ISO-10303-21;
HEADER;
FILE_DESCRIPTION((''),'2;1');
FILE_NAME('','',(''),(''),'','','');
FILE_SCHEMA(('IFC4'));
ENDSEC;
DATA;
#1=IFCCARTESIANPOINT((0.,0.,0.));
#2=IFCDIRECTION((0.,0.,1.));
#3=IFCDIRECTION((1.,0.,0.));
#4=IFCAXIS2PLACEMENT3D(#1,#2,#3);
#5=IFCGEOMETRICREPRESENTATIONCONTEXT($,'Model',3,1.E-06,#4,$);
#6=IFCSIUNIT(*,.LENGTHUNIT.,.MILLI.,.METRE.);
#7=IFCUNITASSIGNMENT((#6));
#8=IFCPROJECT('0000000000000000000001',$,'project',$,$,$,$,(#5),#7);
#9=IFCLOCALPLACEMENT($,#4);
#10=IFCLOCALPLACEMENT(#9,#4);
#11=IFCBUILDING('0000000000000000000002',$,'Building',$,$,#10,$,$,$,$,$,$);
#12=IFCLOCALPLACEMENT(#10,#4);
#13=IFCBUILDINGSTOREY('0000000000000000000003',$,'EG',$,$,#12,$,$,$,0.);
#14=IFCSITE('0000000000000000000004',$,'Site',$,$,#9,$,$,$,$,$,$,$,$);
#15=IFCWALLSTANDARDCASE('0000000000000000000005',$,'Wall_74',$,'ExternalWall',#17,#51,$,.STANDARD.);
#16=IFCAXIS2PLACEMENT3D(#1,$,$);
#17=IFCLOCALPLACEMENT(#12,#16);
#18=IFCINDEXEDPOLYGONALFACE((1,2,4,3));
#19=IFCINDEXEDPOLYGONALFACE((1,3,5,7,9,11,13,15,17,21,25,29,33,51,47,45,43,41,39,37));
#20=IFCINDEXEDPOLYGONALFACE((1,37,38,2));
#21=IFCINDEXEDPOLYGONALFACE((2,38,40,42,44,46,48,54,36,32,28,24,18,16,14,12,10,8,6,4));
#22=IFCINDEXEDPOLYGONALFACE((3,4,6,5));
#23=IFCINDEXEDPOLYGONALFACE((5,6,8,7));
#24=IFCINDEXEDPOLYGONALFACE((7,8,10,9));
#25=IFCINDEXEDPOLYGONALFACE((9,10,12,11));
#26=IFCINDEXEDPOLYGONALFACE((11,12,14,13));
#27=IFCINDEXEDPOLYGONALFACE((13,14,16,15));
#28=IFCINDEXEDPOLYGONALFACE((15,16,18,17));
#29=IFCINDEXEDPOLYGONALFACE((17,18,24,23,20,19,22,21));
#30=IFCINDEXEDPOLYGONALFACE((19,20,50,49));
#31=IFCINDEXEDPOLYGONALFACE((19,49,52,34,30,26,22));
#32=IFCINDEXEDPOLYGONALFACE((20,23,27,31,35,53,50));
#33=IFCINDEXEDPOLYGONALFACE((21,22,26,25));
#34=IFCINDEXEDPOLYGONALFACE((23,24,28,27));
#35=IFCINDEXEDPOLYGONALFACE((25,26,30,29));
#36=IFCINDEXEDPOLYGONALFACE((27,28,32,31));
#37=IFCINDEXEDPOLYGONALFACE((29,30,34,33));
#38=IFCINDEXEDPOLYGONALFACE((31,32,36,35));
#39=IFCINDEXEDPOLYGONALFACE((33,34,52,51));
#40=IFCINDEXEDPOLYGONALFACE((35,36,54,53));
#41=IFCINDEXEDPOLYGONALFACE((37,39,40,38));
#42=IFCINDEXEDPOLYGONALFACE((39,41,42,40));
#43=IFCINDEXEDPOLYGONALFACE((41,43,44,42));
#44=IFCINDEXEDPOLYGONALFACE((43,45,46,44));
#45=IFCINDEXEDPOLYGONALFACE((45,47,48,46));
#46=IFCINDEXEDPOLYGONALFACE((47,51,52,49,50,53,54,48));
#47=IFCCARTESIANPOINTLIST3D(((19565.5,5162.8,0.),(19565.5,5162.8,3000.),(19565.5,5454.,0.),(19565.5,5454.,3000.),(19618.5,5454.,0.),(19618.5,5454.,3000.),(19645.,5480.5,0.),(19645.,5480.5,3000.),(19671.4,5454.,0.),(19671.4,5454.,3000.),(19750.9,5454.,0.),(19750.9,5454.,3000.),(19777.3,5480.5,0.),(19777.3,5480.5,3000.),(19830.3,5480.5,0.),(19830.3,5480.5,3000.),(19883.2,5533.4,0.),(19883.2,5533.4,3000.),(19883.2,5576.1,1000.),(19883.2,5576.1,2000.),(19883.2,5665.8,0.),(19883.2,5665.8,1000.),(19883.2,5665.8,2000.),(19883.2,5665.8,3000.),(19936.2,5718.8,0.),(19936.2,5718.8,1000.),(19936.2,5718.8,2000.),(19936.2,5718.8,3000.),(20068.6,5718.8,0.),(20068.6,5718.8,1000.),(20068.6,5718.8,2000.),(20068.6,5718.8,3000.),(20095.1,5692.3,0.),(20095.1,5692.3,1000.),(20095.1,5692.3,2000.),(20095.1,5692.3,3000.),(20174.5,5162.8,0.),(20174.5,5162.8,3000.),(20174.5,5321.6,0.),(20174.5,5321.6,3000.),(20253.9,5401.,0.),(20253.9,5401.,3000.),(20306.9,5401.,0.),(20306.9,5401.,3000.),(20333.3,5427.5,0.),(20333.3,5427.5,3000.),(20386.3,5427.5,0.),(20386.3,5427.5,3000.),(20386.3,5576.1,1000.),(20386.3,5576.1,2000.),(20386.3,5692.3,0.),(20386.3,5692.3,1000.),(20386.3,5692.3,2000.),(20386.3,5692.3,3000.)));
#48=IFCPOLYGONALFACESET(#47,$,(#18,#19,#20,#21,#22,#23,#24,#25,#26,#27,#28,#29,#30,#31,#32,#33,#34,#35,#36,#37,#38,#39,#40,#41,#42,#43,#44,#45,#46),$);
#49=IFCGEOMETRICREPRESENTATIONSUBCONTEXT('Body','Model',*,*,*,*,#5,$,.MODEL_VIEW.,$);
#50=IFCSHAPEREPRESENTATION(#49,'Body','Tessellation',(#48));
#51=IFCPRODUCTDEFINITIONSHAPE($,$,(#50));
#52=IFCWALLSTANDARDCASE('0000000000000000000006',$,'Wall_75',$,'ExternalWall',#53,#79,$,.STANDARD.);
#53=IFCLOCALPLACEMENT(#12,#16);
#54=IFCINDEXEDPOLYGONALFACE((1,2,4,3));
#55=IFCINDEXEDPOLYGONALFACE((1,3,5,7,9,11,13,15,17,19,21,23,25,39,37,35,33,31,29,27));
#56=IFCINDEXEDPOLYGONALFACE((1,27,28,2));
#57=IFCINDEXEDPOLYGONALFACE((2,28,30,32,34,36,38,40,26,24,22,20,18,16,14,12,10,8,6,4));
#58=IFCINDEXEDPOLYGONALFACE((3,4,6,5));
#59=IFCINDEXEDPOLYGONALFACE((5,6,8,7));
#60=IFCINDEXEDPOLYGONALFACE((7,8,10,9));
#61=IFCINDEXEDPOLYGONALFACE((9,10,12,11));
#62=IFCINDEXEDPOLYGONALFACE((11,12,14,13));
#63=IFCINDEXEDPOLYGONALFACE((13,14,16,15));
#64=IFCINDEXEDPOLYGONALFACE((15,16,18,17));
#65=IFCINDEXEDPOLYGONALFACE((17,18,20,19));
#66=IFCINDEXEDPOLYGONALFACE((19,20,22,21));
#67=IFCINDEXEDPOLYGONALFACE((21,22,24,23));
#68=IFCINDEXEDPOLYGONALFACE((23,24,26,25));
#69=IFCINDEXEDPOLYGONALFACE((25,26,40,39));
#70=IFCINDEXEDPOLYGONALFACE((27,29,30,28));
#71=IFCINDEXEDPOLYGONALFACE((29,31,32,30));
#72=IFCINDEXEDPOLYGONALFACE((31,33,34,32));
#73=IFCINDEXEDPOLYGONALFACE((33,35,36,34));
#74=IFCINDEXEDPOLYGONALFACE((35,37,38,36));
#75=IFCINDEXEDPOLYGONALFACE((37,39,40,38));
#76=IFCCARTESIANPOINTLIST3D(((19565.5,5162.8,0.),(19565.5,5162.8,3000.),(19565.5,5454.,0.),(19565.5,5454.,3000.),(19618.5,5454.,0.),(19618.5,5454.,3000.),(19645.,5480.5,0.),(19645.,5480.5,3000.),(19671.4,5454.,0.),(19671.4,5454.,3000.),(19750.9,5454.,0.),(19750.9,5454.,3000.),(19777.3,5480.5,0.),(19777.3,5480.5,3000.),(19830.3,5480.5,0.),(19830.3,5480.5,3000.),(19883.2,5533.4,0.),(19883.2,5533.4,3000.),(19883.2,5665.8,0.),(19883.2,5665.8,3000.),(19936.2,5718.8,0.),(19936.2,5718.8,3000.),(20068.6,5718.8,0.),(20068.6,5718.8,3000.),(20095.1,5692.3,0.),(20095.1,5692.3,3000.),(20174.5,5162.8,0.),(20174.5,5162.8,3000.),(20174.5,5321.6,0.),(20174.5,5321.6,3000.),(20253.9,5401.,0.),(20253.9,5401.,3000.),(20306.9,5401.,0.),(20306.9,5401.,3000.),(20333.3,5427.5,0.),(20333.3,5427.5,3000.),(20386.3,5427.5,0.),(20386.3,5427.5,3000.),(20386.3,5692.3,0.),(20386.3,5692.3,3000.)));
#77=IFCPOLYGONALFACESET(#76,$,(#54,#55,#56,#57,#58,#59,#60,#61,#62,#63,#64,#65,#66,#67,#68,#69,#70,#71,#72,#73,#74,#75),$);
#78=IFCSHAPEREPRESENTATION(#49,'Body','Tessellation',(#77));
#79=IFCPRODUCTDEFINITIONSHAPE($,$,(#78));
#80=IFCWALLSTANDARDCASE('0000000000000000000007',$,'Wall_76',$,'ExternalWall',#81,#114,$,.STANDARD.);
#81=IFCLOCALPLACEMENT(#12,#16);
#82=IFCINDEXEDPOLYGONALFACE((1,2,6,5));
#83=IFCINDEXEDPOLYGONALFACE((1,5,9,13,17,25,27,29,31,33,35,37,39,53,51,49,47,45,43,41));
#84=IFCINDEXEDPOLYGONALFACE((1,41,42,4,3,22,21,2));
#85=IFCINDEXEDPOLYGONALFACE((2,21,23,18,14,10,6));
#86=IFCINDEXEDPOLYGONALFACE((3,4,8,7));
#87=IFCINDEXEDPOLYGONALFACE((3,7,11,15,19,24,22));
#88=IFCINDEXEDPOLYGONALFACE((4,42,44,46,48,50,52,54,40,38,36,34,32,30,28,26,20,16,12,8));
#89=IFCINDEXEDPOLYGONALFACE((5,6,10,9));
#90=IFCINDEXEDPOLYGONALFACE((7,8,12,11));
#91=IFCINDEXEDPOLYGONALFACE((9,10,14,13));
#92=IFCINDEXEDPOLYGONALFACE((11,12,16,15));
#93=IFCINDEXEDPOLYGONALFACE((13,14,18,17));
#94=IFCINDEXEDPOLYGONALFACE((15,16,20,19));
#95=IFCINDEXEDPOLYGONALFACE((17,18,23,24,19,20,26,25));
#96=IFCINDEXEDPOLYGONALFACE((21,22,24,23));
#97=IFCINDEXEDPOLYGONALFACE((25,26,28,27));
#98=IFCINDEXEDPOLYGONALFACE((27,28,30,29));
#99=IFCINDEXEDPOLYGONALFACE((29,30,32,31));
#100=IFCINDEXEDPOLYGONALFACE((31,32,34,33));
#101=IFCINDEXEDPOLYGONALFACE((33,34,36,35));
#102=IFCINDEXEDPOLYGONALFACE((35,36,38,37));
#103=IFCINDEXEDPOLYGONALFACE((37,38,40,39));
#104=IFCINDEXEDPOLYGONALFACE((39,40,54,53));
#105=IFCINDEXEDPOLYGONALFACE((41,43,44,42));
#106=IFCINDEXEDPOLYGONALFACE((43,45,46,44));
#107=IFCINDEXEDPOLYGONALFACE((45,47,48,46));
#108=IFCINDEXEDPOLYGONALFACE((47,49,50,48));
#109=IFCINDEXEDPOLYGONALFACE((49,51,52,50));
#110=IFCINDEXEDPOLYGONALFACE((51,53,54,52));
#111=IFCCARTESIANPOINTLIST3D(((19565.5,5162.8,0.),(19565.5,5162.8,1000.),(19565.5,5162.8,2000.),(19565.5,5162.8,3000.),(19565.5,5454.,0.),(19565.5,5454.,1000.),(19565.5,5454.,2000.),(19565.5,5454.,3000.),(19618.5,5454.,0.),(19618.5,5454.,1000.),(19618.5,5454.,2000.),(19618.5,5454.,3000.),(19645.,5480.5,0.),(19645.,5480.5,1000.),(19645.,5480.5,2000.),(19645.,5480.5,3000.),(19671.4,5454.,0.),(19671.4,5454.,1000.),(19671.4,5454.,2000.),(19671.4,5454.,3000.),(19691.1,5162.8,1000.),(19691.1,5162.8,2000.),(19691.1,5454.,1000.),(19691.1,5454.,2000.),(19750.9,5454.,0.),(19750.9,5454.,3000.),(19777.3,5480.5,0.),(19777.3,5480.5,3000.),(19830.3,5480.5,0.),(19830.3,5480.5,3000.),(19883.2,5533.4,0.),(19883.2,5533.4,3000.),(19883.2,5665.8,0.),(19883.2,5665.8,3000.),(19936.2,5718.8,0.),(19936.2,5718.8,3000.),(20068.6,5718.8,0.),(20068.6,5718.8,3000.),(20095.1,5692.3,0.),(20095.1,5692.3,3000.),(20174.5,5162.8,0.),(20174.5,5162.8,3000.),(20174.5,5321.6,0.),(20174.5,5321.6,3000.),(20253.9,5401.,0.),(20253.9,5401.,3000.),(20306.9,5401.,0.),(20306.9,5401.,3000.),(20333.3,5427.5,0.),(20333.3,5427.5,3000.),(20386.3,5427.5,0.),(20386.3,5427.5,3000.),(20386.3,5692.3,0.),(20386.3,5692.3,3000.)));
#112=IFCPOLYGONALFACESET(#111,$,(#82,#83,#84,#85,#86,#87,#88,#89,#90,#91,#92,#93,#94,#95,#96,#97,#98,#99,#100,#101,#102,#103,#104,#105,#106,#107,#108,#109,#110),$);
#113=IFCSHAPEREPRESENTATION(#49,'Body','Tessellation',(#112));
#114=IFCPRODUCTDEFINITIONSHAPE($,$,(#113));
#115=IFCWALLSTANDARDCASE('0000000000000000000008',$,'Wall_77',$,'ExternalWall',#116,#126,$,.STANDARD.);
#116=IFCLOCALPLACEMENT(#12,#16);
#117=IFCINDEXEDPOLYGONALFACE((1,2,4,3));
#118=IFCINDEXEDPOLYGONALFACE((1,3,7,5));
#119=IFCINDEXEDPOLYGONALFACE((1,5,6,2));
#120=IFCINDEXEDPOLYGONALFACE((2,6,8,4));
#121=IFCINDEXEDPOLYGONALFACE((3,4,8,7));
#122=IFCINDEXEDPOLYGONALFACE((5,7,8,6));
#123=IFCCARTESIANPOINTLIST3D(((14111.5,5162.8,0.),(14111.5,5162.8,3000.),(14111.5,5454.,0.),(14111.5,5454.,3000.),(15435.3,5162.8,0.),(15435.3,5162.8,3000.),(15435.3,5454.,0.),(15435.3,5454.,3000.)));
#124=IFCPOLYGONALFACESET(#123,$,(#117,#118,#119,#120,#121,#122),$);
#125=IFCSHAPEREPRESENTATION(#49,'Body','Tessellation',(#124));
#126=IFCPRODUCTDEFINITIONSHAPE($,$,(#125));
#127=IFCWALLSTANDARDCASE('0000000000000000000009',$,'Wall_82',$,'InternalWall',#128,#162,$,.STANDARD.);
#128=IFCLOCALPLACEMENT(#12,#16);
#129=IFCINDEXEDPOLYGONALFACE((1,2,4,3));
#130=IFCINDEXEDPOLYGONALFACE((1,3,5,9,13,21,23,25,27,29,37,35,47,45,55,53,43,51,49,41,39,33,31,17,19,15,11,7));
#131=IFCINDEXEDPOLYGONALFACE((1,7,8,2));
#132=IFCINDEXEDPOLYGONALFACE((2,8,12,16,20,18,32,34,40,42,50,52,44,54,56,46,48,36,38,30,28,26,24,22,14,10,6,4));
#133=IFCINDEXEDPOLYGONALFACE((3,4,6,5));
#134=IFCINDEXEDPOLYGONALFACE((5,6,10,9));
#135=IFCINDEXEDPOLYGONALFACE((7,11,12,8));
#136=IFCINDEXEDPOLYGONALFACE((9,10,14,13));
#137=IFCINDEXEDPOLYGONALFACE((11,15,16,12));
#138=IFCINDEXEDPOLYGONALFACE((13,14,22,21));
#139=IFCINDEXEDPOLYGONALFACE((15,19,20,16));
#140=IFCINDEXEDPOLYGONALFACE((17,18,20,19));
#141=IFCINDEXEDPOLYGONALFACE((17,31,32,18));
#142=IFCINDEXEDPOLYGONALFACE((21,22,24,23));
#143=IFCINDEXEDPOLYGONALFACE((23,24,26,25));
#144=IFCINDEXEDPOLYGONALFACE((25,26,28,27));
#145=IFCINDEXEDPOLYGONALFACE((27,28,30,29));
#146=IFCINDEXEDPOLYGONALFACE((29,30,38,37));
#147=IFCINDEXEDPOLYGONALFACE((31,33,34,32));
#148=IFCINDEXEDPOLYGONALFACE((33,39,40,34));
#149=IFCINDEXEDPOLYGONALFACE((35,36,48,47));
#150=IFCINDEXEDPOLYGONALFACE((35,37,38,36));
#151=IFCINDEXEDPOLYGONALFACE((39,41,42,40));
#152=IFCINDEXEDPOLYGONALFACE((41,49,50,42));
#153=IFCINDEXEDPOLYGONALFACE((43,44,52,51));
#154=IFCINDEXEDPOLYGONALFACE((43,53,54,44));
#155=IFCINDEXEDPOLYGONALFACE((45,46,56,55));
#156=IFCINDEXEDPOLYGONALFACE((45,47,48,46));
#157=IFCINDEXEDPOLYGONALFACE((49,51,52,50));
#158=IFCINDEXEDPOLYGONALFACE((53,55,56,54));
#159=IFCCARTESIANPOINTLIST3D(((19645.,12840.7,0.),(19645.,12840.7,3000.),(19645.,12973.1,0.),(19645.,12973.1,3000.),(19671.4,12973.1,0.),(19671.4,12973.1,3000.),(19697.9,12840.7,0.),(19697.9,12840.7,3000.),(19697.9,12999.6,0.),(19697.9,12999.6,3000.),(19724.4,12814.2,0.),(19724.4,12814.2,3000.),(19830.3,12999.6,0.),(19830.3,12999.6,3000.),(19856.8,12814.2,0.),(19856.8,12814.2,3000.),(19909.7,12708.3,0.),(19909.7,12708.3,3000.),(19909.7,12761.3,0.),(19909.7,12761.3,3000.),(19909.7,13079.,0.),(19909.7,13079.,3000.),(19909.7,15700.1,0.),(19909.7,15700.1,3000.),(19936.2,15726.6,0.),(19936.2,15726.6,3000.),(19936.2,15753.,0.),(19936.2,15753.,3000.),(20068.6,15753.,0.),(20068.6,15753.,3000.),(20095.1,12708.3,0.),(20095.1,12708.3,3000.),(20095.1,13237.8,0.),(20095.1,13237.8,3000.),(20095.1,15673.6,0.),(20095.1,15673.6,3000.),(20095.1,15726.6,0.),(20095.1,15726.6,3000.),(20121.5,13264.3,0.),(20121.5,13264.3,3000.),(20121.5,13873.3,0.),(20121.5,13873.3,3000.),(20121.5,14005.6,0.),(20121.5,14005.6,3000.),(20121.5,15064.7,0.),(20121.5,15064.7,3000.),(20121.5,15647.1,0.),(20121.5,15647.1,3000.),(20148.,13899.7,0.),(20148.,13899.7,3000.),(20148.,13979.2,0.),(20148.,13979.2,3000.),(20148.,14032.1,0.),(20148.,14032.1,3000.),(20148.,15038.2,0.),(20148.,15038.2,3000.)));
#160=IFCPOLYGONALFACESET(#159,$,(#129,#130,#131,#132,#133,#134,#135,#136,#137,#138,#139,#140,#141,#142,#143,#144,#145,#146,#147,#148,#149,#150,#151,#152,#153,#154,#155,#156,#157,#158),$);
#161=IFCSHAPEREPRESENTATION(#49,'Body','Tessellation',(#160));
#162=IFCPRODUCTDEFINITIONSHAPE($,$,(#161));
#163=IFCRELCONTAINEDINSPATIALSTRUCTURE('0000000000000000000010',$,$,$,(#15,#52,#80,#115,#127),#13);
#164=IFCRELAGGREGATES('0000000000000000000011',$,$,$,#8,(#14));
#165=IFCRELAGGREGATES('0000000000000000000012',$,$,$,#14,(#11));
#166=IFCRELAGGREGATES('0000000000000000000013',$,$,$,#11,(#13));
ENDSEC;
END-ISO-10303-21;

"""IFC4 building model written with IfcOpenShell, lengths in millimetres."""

from ifc_helpers import new_model, si_unit, frame, origin_with_axes, place, context, subcontext, project, spatial, polyline, rectangle, outline, extrude, element, save


model = new_model("IFC4")

# Units and contexts
model_context = context("Model", 3, precision=1e-06, world=origin_with_axes())
body_context = subcontext(model_context, "Body", "Model", "MODEL_VIEW")
ifc_project = project(units=[si_unit("LENGTHUNIT", "METRE", prefix="MILLI")], contexts=[model_context])

# Site, building, storey
site_placement = place(None, origin_with_axes())
site = spatial("IfcSite", under=ifc_project, at=site_placement, Name="Site")
building_placement = place(site_placement, origin_with_axes())
building = spatial("IfcBuilding", under=site, at=building_placement, Name="Building")
storey_placement = place(building_placement, origin_with_axes())
storey = spatial("IfcBuildingStorey", under=building, at=storey_placement, Name="EG", Elevation=0.0)

# Wall, opening
wall_1_placement = place(storey_placement, origin_with_axes())
wall_1 = element("IfcWallStandardCase", 1, at=wall_1_placement, inside=storey, Name="Wall_74", ObjectType="ExternalWall", PredefinedType="STANDARD", context=body_context, shape_type="SweptSolid", body=[
    extrude(outline(polyline([(19565.5, 5162.8, 0.0), (19565.5, 5454.0, 0.0), (19618.5, 5454.0, 0.0), (19645.0, 5480.5, 0.0), (19671.4, 5454.0, 0.0), (19750.9, 5454.0, 0.0), (19777.3, 5480.5, 0.0), (19830.3, 5480.5, 0.0), (19883.2, 5533.4, 0.0), (19883.2, 5665.8, 0.0), (19936.2, 5718.8, 0.0), (20068.6, 5718.8, 0.0), (20095.1, 5692.3, 0.0), (20386.3, 5692.3, 0.0), (20386.3, 5427.5, 0.0), (20333.3, 5427.5, 0.0), (20306.9, 5401.0, 0.0), (20253.9, 5401.0, 0.0), (20174.5, 5321.6, 0.0), (20174.5, 5162.8, 0.0), (19565.5, 5162.8, 0.0)])), origin_with_axes(), (0.0, 0.0, 1.0), 3000.0),
])
opening_1_placement = place(wall_1_placement, origin_with_axes())
element("IfcOpeningElement", 2, at=opening_1_placement, inside=storey, cuts=wall_1, context=body_context, shape_type="SweptSolid", body=[
    extrude(rectangle(XDim=2956.0, YDim=240.0), frame((20376.7, 5696.1, 1000.0), z_axis=(0.0, 0.0, 1.0), x_axis=(1.0, 0.0, 0.0)), (0.0, 0.0, 1.0), 1000.0),
])

# Wall
wall_2_placement = place(storey_placement, origin_with_axes())
element("IfcWallStandardCase", 3, at=wall_2_placement, inside=storey, Name="Wall_75", ObjectType="ExternalWall", PredefinedType="STANDARD", context=body_context, shape_type="SweptSolid", body=[
    extrude(outline(polyline([(19565.5, 5162.8, 0.0), (19565.5, 5454.0, 0.0), (19618.5, 5454.0, 0.0), (19645.0, 5480.5, 0.0), (19671.4, 5454.0, 0.0), (19750.9, 5454.0, 0.0), (19777.3, 5480.5, 0.0), (19830.3, 5480.5, 0.0), (19883.2, 5533.4, 0.0), (19883.2, 5665.8, 0.0), (19936.2, 5718.8, 0.0), (20068.6, 5718.8, 0.0), (20095.1, 5692.3, 0.0), (20386.3, 5692.3, 0.0), (20386.3, 5427.5, 0.0), (20333.3, 5427.5, 0.0), (20306.9, 5401.0, 0.0), (20253.9, 5401.0, 0.0), (20174.5, 5321.6, 0.0), (20174.5, 5162.8, 0.0), (19565.5, 5162.8, 0.0)])), origin_with_axes(), (0.0, 0.0, 1.0), 3000.0),
])

# Wall, opening
wall_3_placement = place(storey_placement, origin_with_axes())
wall_3 = element("IfcWallStandardCase", 4, at=wall_3_placement, inside=storey, Name="Wall_76", ObjectType="ExternalWall", PredefinedType="STANDARD", context=body_context, shape_type="SweptSolid", body=[
    extrude(outline(polyline([(19565.5, 5162.8, 0.0), (19565.5, 5454.0, 0.0), (19618.5, 5454.0, 0.0), (19645.0, 5480.5, 0.0), (19671.4, 5454.0, 0.0), (19750.9, 5454.0, 0.0), (19777.3, 5480.5, 0.0), (19830.3, 5480.5, 0.0), (19883.2, 5533.4, 0.0), (19883.2, 5665.8, 0.0), (19936.2, 5718.8, 0.0), (20068.6, 5718.8, 0.0), (20095.1, 5692.3, 0.0), (20386.3, 5692.3, 0.0), (20386.3, 5427.5, 0.0), (20333.3, 5427.5, 0.0), (20306.9, 5401.0, 0.0), (20253.9, 5401.0, 0.0), (20174.5, 5321.6, 0.0), (20174.5, 5162.8, 0.0), (19565.5, 5162.8, 0.0)])), origin_with_axes(), (0.0, 0.0, 1.0), 3000.0),
])
opening_2_placement = place(wall_3_placement, origin_with_axes())
element("IfcOpeningElement", 5, at=opening_2_placement, inside=storey, cuts=wall_3, context=body_context, shape_type="SweptSolid", body=[
    extrude(rectangle(XDim=694.1, YDim=240.0), frame((19571.1, 5168.3, 1000.0), z_axis=(0.0, 0.0, 1.0), x_axis=(0.0, 1.0, 0.0)), (0.0, 0.0, 1.0), 1000.0),
])

# Walls
for number, where, z_axis, x_axis, name in (
    (6, (0.0, 0.0, 0.0), (0.0, 0.0, 1.0), (1.0, 0.0, 0.0), "Wall_77"),
):
    element("IfcWallStandardCase", number, at=place(storey_placement, frame(where, z_axis=z_axis, x_axis=x_axis)), inside=storey, Name=name, ObjectType="ExternalWall", PredefinedType="STANDARD", context=body_context, shape_type="SweptSolid", body=[
        extrude(outline(polyline([(14111.5, 5162.8, 0.0), (14111.5, 5454.0, 0.0), (15435.3, 5454.0, 0.0), (15435.3, 5162.8, 0.0), (14111.5, 5162.8, 0.0)])), origin_with_axes(), (0.0, 0.0, 1.0), 3000.0),
    ])
wall_4_placement = place(storey_placement, origin_with_axes())
element("IfcWallStandardCase", 7, at=wall_4_placement, inside=storey, Name="Wall_82", ObjectType="InternalWall", PredefinedType="STANDARD", context=body_context, shape_type="SweptSolid", body=[
    extrude(outline(polyline([(19909.7, 12708.3, 0.0), (19909.7, 12761.3, 0.0), (19856.8, 12814.2, 0.0), (19724.4, 12814.2, 0.0), (19697.9, 12840.7, 0.0), (19645.0, 12840.7, 0.0), (19645.0, 12973.1, 0.0), (19671.4, 12973.1, 0.0), (19697.9, 12999.6, 0.0), (19830.3, 12999.6, 0.0), (19909.7, 13079.0, 0.0), (19909.7, 15700.1, 0.0), (19936.2, 15726.6, 0.0), (19936.2, 15753.0, 0.0), (20068.6, 15753.0, 0.0), (20095.1, 15726.6, 0.0), (20095.1, 15673.6, 0.0), (20121.5, 15647.1, 0.0), (20121.5, 15064.7, 0.0), (20148.0, 15038.2, 0.0), (20148.0, 14032.1, 0.0), (20121.5, 14005.6, 0.0), (20148.0, 13979.2, 0.0), (20148.0, 13899.7, 0.0), (20121.5, 13873.3, 0.0), (20121.5, 13264.3, 0.0), (20095.1, 13237.8, 0.0), (20095.1, 12708.3, 0.0), (19909.7, 12708.3, 0.0)])), origin_with_axes(), (0.0, 0.0, 1.0), 3000.0),
])

save(model, "model.ifc")
